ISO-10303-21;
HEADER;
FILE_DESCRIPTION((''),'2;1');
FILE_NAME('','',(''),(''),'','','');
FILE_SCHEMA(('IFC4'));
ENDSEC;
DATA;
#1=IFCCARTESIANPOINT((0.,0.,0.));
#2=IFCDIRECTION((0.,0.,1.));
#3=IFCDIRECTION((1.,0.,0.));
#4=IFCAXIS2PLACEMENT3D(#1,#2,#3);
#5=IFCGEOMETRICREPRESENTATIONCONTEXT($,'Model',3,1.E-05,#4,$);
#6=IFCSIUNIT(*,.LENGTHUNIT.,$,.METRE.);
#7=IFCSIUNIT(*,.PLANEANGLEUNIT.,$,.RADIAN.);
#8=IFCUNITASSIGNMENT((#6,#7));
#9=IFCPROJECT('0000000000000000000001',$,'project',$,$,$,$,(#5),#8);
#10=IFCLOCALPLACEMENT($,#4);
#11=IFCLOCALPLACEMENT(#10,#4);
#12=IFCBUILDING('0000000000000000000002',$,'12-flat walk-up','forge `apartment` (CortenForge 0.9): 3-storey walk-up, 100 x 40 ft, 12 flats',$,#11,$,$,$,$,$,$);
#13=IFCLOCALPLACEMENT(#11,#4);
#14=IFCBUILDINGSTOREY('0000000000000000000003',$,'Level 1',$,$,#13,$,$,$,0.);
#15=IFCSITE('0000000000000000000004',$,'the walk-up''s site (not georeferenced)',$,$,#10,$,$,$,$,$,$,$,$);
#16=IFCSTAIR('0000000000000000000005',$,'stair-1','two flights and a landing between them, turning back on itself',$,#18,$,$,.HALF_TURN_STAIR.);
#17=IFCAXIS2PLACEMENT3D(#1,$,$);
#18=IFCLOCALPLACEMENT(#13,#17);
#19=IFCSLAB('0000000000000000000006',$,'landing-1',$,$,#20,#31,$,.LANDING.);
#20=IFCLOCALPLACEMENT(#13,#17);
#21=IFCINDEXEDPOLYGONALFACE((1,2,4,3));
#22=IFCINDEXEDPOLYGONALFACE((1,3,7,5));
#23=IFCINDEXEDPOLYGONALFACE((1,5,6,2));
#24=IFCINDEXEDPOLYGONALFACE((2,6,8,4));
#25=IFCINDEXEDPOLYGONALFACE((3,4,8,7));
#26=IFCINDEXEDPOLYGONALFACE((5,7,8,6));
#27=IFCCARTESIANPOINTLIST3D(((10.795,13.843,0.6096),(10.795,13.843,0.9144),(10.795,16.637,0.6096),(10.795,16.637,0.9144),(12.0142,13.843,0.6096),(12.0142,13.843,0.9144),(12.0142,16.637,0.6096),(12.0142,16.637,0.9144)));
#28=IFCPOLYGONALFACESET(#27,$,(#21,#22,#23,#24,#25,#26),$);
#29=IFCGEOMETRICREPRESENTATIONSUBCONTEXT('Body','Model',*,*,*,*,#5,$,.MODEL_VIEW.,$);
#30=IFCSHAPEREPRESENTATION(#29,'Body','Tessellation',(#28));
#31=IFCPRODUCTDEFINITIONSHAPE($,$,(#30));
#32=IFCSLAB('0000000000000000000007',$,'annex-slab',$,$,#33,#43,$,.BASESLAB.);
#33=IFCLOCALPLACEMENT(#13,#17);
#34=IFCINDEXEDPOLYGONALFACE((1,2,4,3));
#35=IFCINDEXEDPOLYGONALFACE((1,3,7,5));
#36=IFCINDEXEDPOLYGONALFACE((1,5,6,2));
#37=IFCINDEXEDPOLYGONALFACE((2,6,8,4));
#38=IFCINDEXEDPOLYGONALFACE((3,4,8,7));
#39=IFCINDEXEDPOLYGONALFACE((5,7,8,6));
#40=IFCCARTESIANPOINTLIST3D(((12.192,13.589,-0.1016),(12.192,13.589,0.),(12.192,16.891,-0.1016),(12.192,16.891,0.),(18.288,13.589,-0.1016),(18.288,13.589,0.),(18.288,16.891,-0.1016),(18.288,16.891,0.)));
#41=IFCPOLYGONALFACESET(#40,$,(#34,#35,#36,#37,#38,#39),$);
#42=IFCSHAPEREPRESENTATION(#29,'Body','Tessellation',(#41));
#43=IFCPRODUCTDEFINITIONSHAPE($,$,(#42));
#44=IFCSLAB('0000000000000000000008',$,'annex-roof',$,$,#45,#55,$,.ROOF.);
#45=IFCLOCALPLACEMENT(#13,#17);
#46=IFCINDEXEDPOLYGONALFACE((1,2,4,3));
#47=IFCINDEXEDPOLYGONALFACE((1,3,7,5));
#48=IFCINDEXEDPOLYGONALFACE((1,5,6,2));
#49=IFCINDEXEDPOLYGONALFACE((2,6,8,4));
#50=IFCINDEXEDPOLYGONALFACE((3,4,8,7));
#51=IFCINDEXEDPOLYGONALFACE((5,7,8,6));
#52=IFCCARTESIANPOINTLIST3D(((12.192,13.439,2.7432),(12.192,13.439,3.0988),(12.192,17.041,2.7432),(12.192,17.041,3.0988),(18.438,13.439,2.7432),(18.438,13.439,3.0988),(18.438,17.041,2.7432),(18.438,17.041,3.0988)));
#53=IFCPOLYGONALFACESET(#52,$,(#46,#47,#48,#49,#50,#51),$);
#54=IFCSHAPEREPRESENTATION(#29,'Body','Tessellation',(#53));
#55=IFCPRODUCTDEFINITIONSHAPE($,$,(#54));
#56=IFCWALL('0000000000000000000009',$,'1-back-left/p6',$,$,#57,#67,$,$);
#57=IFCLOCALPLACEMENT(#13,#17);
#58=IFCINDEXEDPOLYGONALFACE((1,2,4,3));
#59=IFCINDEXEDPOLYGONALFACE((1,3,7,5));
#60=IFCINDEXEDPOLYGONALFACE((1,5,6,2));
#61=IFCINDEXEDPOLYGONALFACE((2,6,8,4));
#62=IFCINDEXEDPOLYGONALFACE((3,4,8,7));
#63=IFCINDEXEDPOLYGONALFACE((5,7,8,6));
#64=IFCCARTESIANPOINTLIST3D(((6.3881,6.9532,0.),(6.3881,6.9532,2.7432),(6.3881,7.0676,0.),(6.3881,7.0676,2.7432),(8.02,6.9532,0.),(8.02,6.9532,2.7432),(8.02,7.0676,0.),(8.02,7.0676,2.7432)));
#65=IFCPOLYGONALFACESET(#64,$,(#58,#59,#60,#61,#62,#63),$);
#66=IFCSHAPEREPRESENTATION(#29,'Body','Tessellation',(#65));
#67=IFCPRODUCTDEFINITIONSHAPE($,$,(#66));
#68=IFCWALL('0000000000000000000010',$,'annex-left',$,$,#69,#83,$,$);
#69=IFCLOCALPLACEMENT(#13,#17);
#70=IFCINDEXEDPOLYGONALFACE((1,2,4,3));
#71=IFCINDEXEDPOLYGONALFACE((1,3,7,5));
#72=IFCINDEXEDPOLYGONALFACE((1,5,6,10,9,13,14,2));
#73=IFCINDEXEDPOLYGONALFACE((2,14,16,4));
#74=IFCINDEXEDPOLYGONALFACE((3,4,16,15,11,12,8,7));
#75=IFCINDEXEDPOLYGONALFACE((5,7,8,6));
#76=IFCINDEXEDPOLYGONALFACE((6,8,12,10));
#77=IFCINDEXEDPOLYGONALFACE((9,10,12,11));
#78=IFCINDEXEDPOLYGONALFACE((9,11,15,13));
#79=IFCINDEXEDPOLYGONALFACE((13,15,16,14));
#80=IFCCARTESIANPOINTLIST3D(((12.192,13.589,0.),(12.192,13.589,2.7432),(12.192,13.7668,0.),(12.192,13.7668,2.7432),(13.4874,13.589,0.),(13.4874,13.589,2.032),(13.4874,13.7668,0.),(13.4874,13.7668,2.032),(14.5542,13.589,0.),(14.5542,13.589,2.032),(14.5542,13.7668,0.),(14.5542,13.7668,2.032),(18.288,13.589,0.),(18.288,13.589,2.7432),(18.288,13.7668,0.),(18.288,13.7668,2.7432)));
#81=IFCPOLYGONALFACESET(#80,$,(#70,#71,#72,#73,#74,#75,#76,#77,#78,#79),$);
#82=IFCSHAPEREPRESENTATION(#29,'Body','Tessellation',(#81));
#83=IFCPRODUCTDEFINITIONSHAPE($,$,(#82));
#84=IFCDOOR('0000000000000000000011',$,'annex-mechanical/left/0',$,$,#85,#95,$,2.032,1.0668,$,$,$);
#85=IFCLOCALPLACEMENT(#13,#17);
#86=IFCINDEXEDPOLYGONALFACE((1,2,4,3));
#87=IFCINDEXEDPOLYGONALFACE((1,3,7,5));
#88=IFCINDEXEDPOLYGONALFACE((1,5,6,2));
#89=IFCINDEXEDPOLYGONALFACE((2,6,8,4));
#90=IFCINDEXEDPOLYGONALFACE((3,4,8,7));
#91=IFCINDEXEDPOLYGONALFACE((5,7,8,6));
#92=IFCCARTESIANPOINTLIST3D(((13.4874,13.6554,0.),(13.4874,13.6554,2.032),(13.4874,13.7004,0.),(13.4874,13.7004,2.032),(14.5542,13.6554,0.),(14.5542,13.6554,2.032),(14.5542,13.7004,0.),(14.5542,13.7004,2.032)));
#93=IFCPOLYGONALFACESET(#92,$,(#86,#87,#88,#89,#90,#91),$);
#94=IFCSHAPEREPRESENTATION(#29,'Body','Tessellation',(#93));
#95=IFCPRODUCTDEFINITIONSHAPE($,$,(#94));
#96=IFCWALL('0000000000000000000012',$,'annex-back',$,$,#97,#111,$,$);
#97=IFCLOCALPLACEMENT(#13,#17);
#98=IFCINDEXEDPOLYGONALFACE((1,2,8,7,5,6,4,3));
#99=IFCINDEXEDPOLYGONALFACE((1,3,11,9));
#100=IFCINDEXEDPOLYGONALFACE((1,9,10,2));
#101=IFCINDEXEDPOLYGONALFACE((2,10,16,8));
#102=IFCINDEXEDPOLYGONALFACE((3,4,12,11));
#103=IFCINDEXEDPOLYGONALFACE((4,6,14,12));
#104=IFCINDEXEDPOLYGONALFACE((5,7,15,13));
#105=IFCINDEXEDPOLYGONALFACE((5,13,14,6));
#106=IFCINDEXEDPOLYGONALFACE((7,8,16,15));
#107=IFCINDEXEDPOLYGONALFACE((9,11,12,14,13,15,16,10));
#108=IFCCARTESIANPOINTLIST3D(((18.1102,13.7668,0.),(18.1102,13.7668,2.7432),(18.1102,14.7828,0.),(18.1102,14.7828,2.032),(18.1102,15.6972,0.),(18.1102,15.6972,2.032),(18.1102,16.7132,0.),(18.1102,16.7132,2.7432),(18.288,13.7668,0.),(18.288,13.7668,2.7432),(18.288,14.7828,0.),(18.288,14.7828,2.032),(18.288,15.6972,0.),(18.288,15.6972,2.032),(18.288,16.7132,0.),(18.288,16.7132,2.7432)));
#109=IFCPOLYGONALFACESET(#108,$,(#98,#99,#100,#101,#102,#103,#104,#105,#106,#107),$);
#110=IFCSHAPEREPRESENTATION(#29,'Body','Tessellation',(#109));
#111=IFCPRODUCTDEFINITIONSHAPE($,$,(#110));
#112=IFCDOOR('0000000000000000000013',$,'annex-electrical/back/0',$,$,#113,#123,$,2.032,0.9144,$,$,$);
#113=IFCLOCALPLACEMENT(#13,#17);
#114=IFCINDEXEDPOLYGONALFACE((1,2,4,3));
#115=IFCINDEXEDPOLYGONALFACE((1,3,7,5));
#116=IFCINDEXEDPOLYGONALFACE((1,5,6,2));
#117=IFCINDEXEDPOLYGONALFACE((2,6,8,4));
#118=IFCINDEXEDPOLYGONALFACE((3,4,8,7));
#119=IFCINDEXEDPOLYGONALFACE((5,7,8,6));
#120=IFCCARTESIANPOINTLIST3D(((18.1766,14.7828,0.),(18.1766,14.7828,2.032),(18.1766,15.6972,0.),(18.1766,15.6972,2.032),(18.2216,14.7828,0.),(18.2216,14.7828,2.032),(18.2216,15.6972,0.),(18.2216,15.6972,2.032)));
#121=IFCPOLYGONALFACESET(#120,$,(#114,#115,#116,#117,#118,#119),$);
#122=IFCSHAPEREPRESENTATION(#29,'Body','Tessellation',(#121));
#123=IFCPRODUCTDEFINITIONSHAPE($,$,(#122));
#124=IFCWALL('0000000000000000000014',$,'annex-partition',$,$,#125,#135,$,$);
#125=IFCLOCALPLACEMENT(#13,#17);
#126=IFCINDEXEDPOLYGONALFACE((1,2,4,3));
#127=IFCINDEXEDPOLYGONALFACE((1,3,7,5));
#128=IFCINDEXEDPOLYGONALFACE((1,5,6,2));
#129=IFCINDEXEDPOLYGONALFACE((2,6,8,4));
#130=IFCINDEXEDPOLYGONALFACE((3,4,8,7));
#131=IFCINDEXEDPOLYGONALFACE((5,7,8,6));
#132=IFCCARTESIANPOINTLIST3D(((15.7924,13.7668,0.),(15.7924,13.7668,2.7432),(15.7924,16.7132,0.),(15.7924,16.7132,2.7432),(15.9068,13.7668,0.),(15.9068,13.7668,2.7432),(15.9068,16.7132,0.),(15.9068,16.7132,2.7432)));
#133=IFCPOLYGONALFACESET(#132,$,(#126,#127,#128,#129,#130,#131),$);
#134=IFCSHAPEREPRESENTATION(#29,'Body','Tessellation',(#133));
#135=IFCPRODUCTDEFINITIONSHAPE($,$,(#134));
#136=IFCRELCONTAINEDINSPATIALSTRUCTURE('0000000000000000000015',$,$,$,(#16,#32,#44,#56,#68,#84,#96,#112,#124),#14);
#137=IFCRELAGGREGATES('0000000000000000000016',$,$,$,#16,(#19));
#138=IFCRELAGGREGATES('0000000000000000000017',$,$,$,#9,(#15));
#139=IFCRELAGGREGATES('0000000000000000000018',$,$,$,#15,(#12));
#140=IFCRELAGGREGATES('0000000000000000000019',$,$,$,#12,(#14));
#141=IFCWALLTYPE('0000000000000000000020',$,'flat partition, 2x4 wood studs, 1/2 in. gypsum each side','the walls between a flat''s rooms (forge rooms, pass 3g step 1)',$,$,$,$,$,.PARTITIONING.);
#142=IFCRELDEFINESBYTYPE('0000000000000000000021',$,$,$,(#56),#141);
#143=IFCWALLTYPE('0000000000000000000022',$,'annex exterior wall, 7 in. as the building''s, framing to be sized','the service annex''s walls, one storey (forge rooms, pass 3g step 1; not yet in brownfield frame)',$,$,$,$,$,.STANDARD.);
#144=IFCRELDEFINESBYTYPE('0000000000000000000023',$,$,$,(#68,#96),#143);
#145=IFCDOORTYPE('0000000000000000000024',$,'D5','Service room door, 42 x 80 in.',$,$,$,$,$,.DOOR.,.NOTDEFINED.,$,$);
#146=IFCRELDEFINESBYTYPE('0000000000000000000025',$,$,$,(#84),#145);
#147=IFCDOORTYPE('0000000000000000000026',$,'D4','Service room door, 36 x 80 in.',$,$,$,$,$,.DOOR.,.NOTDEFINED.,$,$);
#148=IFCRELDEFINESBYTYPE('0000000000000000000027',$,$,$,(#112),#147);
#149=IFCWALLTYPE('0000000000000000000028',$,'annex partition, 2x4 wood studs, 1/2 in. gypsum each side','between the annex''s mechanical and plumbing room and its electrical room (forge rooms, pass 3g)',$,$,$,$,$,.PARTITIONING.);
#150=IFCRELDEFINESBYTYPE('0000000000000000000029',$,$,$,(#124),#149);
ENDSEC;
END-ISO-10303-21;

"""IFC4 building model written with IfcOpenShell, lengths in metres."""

from ifc_helpers import new_model, si_unit, frame, frame_2d, origin, origin_with_axes, place, context, subcontext, project, spatial, rectangle, extrude, type_object, element, fill, aggregate, save


model = new_model("IFC4")

# Units and contexts
model_context = context("Model", 3, precision=1e-05, world=origin_with_axes())
body_context = subcontext(model_context, "Body", "Model", "MODEL_VIEW")
ifc_project = project(units=[si_unit("LENGTHUNIT", "METRE"), si_unit("PLANEANGLEUNIT", "RADIAN")], contexts=[model_context])

# Site, building, storey
site_placement = place(None, origin_with_axes())
site = spatial("IfcSite", under=ifc_project, at=site_placement, Name="the walk-up's site (not georeferenced)")
building_placement = place(site_placement, origin_with_axes())
building = spatial("IfcBuilding", under=site, at=building_placement, Name="12-flat walk-up", Description="forge `apartment` (CortenForge 0.9): 3-storey walk-up, 100 x 40 ft, 12 flats")
storey_placement = place(building_placement, origin_with_axes())
storey = spatial("IfcBuildingStorey", under=building, at=storey_placement, Name="Level 1", Elevation=0.0)

# Stair, slab
stair_placement = place(storey_placement, origin_with_axes())
stair = element("IfcStair", 1, at=stair_placement, inside=storey, Name="stair-1", Description="two flights and a landing between them, turning back on itself", PredefinedType="HALF_TURN_STAIR")
slab_1_placement = place(stair_placement, frame((10.795, 13.843, 0.6096), z_axis=(0.0, 0.0, 1.0), x_axis=(1.0, 0.0, 0.0)))
slab_1 = element("IfcSlab", 2, at=slab_1_placement, Name="landing-1", PredefinedType="LANDING", context=body_context, shape_type="SweptSolid", body=[
    extrude(rectangle(XDim=1.2192, YDim=2.794, at=frame_2d((0.6096, 1.397))), origin(), (0.0, 0.0, 1.0), 0.3048),
])
aggregate(stair, [slab_1])

# Slabs
slab_2_placement = place(storey_placement, frame((12.192, 13.589, -0.1016), z_axis=(0.0, 0.0, 1.0), x_axis=(1.0, 0.0, 0.0)))
element("IfcSlab", 3, at=slab_2_placement, inside=storey, Name="annex-slab", PredefinedType="BASESLAB", context=body_context, shape_type="SweptSolid", body=[
    extrude(rectangle(XDim=6.096, YDim=3.302, at=frame_2d((3.048, 1.651))), origin(), (0.0, 0.0, 1.0), 0.1016),
])
slab_3_placement = place(storey_placement, frame((12.192, 13.439, 2.7432), z_axis=(0.0, 0.0, 1.0), x_axis=(1.0, 0.0, 0.0)))
element("IfcSlab", 4, at=slab_3_placement, inside=storey, Name="annex-roof", PredefinedType="ROOF", context=body_context, shape_type="SweptSolid", body=[
    extrude(rectangle(XDim=6.246, YDim=3.602, at=frame_2d((3.123, 1.801))), origin(), (0.0, 0.0, 1.0), 0.3556),
])

# Wall
wall_type_1 = type_object("IfcWallType", Name="flat partition, 2x4 wood studs, 1/2 in. gypsum each side", Description="the walls between a flat's rooms (forge rooms, pass 3g step 1)", PredefinedType="PARTITIONING")
wall_1_placement = place(storey_placement, frame((6.3881, 6.9532, 0.0), z_axis=(0.0, 0.0, 1.0), x_axis=(1.0, 0.0, 0.0)))
element("IfcWall", 5, at=wall_1_placement, inside=storey, type_object=wall_type_1, Name="1-back-left/p6", context=body_context, shape_type="SweptSolid", body=[
    extrude(rectangle(XDim=1.6319, YDim=0.1143, at=frame_2d((0.816, 0.0572))), origin(), (0.0, 0.0, 1.0), 2.7432),
])

# Walls, openings, doors
wall_type_2 = type_object("IfcWallType", Name="annex exterior wall, 7 in. as the building's, framing to be sized", Description="the service annex's walls, one storey (forge rooms, pass 3g step 1; not yet in brownfield frame)", PredefinedType="STANDARD")
wall_2_placement = place(storey_placement, frame((12.192, 13.589, 0.0), z_axis=(0.0, 0.0, 1.0), x_axis=(1.0, 0.0, 0.0)))
wall_2 = element("IfcWall", 6, at=wall_2_placement, inside=storey, type_object=wall_type_2, Name="annex-left", context=body_context, shape_type="SweptSolid", body=[
    extrude(rectangle(XDim=6.096, YDim=0.1778, at=frame_2d((3.048, 0.0889))), origin(), (0.0, 0.0, 1.0), 2.7432),
])
opening_1_placement = place(wall_2_placement, frame((1.2954, 0.0, 0.0), z_axis=(0.0, 0.0, 1.0), x_axis=(1.0, 0.0, 0.0)))
opening_1 = element("IfcOpeningElement", 7, at=opening_1_placement, cuts=wall_2, PredefinedType="OPENING", context=body_context, shape_type="SweptSolid", body=[
    extrude(rectangle(XDim=1.0668, YDim=0.1778, at=frame_2d((0.5334, 0.0889))), origin(), (0.0, 0.0, 1.0), 2.032),
])
door_type_1 = type_object("IfcDoorType", Name="D5", Description="Service room door, 42 x 80 in.", OperationType="NOTDEFINED", PredefinedType="DOOR")
door_1_placement = place(opening_1_placement, frame((0.0, 0.0664, 0.0), z_axis=(0.0, 0.0, 1.0), x_axis=(1.0, 0.0, 0.0)))
door_1 = element("IfcDoor", 8, at=door_1_placement, inside=storey, type_object=door_type_1, Name="annex-mechanical/left/0", OverallHeight=2.032, OverallWidth=1.0668, context=body_context, shape_type="SweptSolid", body=[
    extrude(rectangle(XDim=1.0668, YDim=0.045, at=frame_2d((0.5334, 0.0225))), origin(), (0.0, 0.0, 1.0), 2.032),
])
fill(opening_1, door_1)
wall_3_placement = place(storey_placement, frame((18.1102, 13.7668, 0.0), z_axis=(0.0, 0.0, 1.0), x_axis=(1.0, 0.0, 0.0)))
wall_3 = element("IfcWall", 9, at=wall_3_placement, inside=storey, type_object=wall_type_2, Name="annex-back", context=body_context, shape_type="SweptSolid", body=[
    extrude(rectangle(XDim=0.1778, YDim=2.9464, at=frame_2d((0.0889, 1.4732))), origin(), (0.0, 0.0, 1.0), 2.7432),
])
opening_2_placement = place(wall_3_placement, frame((0.1778, 1.016, 0.0), z_axis=(0.0, 0.0, 1.0), x_axis=(0.0, 1.0, 0.0)))
opening_2 = element("IfcOpeningElement", 10, at=opening_2_placement, cuts=wall_3, PredefinedType="OPENING", context=body_context, shape_type="SweptSolid", body=[
    extrude(rectangle(XDim=0.9144, YDim=0.1778, at=frame_2d((0.4572, 0.0889))), origin(), (0.0, 0.0, 1.0), 2.032),
])
door_type_2 = type_object("IfcDoorType", Name="D4", Description="Service room door, 36 x 80 in.", OperationType="NOTDEFINED", PredefinedType="DOOR")
door_2_placement = place(opening_2_placement, frame((0.0, 0.0664, 0.0), z_axis=(0.0, 0.0, 1.0), x_axis=(1.0, 0.0, 0.0)))
door_2 = element("IfcDoor", 11, at=door_2_placement, inside=storey, type_object=door_type_2, Name="annex-electrical/back/0", OverallHeight=2.032, OverallWidth=0.9144, context=body_context, shape_type="SweptSolid", body=[
    extrude(rectangle(XDim=0.9144, YDim=0.045, at=frame_2d((0.4572, 0.0225))), origin(), (0.0, 0.0, 1.0), 2.032),
])
fill(opening_2, door_2)

# Wall
wall_type_3 = type_object("IfcWallType", Name="annex partition, 2x4 wood studs, 1/2 in. gypsum each side", Description="between the annex's mechanical and plumbing room and its electrical room (forge rooms, pass 3g)", PredefinedType="PARTITIONING")
wall_4_placement = place(storey_placement, frame((15.7925, 13.7668, 0.0), z_axis=(0.0, 0.0, 1.0), x_axis=(1.0, 0.0, 0.0)))
element("IfcWall", 12, at=wall_4_placement, inside=storey, type_object=wall_type_3, Name="annex-partition", context=body_context, shape_type="SweptSolid", body=[
    extrude(rectangle(XDim=0.1143, YDim=2.9464, at=frame_2d((0.0572, 1.4732))), origin(), (0.0, 0.0, 1.0), 2.7432),
])

save(model, "model.ifc")
